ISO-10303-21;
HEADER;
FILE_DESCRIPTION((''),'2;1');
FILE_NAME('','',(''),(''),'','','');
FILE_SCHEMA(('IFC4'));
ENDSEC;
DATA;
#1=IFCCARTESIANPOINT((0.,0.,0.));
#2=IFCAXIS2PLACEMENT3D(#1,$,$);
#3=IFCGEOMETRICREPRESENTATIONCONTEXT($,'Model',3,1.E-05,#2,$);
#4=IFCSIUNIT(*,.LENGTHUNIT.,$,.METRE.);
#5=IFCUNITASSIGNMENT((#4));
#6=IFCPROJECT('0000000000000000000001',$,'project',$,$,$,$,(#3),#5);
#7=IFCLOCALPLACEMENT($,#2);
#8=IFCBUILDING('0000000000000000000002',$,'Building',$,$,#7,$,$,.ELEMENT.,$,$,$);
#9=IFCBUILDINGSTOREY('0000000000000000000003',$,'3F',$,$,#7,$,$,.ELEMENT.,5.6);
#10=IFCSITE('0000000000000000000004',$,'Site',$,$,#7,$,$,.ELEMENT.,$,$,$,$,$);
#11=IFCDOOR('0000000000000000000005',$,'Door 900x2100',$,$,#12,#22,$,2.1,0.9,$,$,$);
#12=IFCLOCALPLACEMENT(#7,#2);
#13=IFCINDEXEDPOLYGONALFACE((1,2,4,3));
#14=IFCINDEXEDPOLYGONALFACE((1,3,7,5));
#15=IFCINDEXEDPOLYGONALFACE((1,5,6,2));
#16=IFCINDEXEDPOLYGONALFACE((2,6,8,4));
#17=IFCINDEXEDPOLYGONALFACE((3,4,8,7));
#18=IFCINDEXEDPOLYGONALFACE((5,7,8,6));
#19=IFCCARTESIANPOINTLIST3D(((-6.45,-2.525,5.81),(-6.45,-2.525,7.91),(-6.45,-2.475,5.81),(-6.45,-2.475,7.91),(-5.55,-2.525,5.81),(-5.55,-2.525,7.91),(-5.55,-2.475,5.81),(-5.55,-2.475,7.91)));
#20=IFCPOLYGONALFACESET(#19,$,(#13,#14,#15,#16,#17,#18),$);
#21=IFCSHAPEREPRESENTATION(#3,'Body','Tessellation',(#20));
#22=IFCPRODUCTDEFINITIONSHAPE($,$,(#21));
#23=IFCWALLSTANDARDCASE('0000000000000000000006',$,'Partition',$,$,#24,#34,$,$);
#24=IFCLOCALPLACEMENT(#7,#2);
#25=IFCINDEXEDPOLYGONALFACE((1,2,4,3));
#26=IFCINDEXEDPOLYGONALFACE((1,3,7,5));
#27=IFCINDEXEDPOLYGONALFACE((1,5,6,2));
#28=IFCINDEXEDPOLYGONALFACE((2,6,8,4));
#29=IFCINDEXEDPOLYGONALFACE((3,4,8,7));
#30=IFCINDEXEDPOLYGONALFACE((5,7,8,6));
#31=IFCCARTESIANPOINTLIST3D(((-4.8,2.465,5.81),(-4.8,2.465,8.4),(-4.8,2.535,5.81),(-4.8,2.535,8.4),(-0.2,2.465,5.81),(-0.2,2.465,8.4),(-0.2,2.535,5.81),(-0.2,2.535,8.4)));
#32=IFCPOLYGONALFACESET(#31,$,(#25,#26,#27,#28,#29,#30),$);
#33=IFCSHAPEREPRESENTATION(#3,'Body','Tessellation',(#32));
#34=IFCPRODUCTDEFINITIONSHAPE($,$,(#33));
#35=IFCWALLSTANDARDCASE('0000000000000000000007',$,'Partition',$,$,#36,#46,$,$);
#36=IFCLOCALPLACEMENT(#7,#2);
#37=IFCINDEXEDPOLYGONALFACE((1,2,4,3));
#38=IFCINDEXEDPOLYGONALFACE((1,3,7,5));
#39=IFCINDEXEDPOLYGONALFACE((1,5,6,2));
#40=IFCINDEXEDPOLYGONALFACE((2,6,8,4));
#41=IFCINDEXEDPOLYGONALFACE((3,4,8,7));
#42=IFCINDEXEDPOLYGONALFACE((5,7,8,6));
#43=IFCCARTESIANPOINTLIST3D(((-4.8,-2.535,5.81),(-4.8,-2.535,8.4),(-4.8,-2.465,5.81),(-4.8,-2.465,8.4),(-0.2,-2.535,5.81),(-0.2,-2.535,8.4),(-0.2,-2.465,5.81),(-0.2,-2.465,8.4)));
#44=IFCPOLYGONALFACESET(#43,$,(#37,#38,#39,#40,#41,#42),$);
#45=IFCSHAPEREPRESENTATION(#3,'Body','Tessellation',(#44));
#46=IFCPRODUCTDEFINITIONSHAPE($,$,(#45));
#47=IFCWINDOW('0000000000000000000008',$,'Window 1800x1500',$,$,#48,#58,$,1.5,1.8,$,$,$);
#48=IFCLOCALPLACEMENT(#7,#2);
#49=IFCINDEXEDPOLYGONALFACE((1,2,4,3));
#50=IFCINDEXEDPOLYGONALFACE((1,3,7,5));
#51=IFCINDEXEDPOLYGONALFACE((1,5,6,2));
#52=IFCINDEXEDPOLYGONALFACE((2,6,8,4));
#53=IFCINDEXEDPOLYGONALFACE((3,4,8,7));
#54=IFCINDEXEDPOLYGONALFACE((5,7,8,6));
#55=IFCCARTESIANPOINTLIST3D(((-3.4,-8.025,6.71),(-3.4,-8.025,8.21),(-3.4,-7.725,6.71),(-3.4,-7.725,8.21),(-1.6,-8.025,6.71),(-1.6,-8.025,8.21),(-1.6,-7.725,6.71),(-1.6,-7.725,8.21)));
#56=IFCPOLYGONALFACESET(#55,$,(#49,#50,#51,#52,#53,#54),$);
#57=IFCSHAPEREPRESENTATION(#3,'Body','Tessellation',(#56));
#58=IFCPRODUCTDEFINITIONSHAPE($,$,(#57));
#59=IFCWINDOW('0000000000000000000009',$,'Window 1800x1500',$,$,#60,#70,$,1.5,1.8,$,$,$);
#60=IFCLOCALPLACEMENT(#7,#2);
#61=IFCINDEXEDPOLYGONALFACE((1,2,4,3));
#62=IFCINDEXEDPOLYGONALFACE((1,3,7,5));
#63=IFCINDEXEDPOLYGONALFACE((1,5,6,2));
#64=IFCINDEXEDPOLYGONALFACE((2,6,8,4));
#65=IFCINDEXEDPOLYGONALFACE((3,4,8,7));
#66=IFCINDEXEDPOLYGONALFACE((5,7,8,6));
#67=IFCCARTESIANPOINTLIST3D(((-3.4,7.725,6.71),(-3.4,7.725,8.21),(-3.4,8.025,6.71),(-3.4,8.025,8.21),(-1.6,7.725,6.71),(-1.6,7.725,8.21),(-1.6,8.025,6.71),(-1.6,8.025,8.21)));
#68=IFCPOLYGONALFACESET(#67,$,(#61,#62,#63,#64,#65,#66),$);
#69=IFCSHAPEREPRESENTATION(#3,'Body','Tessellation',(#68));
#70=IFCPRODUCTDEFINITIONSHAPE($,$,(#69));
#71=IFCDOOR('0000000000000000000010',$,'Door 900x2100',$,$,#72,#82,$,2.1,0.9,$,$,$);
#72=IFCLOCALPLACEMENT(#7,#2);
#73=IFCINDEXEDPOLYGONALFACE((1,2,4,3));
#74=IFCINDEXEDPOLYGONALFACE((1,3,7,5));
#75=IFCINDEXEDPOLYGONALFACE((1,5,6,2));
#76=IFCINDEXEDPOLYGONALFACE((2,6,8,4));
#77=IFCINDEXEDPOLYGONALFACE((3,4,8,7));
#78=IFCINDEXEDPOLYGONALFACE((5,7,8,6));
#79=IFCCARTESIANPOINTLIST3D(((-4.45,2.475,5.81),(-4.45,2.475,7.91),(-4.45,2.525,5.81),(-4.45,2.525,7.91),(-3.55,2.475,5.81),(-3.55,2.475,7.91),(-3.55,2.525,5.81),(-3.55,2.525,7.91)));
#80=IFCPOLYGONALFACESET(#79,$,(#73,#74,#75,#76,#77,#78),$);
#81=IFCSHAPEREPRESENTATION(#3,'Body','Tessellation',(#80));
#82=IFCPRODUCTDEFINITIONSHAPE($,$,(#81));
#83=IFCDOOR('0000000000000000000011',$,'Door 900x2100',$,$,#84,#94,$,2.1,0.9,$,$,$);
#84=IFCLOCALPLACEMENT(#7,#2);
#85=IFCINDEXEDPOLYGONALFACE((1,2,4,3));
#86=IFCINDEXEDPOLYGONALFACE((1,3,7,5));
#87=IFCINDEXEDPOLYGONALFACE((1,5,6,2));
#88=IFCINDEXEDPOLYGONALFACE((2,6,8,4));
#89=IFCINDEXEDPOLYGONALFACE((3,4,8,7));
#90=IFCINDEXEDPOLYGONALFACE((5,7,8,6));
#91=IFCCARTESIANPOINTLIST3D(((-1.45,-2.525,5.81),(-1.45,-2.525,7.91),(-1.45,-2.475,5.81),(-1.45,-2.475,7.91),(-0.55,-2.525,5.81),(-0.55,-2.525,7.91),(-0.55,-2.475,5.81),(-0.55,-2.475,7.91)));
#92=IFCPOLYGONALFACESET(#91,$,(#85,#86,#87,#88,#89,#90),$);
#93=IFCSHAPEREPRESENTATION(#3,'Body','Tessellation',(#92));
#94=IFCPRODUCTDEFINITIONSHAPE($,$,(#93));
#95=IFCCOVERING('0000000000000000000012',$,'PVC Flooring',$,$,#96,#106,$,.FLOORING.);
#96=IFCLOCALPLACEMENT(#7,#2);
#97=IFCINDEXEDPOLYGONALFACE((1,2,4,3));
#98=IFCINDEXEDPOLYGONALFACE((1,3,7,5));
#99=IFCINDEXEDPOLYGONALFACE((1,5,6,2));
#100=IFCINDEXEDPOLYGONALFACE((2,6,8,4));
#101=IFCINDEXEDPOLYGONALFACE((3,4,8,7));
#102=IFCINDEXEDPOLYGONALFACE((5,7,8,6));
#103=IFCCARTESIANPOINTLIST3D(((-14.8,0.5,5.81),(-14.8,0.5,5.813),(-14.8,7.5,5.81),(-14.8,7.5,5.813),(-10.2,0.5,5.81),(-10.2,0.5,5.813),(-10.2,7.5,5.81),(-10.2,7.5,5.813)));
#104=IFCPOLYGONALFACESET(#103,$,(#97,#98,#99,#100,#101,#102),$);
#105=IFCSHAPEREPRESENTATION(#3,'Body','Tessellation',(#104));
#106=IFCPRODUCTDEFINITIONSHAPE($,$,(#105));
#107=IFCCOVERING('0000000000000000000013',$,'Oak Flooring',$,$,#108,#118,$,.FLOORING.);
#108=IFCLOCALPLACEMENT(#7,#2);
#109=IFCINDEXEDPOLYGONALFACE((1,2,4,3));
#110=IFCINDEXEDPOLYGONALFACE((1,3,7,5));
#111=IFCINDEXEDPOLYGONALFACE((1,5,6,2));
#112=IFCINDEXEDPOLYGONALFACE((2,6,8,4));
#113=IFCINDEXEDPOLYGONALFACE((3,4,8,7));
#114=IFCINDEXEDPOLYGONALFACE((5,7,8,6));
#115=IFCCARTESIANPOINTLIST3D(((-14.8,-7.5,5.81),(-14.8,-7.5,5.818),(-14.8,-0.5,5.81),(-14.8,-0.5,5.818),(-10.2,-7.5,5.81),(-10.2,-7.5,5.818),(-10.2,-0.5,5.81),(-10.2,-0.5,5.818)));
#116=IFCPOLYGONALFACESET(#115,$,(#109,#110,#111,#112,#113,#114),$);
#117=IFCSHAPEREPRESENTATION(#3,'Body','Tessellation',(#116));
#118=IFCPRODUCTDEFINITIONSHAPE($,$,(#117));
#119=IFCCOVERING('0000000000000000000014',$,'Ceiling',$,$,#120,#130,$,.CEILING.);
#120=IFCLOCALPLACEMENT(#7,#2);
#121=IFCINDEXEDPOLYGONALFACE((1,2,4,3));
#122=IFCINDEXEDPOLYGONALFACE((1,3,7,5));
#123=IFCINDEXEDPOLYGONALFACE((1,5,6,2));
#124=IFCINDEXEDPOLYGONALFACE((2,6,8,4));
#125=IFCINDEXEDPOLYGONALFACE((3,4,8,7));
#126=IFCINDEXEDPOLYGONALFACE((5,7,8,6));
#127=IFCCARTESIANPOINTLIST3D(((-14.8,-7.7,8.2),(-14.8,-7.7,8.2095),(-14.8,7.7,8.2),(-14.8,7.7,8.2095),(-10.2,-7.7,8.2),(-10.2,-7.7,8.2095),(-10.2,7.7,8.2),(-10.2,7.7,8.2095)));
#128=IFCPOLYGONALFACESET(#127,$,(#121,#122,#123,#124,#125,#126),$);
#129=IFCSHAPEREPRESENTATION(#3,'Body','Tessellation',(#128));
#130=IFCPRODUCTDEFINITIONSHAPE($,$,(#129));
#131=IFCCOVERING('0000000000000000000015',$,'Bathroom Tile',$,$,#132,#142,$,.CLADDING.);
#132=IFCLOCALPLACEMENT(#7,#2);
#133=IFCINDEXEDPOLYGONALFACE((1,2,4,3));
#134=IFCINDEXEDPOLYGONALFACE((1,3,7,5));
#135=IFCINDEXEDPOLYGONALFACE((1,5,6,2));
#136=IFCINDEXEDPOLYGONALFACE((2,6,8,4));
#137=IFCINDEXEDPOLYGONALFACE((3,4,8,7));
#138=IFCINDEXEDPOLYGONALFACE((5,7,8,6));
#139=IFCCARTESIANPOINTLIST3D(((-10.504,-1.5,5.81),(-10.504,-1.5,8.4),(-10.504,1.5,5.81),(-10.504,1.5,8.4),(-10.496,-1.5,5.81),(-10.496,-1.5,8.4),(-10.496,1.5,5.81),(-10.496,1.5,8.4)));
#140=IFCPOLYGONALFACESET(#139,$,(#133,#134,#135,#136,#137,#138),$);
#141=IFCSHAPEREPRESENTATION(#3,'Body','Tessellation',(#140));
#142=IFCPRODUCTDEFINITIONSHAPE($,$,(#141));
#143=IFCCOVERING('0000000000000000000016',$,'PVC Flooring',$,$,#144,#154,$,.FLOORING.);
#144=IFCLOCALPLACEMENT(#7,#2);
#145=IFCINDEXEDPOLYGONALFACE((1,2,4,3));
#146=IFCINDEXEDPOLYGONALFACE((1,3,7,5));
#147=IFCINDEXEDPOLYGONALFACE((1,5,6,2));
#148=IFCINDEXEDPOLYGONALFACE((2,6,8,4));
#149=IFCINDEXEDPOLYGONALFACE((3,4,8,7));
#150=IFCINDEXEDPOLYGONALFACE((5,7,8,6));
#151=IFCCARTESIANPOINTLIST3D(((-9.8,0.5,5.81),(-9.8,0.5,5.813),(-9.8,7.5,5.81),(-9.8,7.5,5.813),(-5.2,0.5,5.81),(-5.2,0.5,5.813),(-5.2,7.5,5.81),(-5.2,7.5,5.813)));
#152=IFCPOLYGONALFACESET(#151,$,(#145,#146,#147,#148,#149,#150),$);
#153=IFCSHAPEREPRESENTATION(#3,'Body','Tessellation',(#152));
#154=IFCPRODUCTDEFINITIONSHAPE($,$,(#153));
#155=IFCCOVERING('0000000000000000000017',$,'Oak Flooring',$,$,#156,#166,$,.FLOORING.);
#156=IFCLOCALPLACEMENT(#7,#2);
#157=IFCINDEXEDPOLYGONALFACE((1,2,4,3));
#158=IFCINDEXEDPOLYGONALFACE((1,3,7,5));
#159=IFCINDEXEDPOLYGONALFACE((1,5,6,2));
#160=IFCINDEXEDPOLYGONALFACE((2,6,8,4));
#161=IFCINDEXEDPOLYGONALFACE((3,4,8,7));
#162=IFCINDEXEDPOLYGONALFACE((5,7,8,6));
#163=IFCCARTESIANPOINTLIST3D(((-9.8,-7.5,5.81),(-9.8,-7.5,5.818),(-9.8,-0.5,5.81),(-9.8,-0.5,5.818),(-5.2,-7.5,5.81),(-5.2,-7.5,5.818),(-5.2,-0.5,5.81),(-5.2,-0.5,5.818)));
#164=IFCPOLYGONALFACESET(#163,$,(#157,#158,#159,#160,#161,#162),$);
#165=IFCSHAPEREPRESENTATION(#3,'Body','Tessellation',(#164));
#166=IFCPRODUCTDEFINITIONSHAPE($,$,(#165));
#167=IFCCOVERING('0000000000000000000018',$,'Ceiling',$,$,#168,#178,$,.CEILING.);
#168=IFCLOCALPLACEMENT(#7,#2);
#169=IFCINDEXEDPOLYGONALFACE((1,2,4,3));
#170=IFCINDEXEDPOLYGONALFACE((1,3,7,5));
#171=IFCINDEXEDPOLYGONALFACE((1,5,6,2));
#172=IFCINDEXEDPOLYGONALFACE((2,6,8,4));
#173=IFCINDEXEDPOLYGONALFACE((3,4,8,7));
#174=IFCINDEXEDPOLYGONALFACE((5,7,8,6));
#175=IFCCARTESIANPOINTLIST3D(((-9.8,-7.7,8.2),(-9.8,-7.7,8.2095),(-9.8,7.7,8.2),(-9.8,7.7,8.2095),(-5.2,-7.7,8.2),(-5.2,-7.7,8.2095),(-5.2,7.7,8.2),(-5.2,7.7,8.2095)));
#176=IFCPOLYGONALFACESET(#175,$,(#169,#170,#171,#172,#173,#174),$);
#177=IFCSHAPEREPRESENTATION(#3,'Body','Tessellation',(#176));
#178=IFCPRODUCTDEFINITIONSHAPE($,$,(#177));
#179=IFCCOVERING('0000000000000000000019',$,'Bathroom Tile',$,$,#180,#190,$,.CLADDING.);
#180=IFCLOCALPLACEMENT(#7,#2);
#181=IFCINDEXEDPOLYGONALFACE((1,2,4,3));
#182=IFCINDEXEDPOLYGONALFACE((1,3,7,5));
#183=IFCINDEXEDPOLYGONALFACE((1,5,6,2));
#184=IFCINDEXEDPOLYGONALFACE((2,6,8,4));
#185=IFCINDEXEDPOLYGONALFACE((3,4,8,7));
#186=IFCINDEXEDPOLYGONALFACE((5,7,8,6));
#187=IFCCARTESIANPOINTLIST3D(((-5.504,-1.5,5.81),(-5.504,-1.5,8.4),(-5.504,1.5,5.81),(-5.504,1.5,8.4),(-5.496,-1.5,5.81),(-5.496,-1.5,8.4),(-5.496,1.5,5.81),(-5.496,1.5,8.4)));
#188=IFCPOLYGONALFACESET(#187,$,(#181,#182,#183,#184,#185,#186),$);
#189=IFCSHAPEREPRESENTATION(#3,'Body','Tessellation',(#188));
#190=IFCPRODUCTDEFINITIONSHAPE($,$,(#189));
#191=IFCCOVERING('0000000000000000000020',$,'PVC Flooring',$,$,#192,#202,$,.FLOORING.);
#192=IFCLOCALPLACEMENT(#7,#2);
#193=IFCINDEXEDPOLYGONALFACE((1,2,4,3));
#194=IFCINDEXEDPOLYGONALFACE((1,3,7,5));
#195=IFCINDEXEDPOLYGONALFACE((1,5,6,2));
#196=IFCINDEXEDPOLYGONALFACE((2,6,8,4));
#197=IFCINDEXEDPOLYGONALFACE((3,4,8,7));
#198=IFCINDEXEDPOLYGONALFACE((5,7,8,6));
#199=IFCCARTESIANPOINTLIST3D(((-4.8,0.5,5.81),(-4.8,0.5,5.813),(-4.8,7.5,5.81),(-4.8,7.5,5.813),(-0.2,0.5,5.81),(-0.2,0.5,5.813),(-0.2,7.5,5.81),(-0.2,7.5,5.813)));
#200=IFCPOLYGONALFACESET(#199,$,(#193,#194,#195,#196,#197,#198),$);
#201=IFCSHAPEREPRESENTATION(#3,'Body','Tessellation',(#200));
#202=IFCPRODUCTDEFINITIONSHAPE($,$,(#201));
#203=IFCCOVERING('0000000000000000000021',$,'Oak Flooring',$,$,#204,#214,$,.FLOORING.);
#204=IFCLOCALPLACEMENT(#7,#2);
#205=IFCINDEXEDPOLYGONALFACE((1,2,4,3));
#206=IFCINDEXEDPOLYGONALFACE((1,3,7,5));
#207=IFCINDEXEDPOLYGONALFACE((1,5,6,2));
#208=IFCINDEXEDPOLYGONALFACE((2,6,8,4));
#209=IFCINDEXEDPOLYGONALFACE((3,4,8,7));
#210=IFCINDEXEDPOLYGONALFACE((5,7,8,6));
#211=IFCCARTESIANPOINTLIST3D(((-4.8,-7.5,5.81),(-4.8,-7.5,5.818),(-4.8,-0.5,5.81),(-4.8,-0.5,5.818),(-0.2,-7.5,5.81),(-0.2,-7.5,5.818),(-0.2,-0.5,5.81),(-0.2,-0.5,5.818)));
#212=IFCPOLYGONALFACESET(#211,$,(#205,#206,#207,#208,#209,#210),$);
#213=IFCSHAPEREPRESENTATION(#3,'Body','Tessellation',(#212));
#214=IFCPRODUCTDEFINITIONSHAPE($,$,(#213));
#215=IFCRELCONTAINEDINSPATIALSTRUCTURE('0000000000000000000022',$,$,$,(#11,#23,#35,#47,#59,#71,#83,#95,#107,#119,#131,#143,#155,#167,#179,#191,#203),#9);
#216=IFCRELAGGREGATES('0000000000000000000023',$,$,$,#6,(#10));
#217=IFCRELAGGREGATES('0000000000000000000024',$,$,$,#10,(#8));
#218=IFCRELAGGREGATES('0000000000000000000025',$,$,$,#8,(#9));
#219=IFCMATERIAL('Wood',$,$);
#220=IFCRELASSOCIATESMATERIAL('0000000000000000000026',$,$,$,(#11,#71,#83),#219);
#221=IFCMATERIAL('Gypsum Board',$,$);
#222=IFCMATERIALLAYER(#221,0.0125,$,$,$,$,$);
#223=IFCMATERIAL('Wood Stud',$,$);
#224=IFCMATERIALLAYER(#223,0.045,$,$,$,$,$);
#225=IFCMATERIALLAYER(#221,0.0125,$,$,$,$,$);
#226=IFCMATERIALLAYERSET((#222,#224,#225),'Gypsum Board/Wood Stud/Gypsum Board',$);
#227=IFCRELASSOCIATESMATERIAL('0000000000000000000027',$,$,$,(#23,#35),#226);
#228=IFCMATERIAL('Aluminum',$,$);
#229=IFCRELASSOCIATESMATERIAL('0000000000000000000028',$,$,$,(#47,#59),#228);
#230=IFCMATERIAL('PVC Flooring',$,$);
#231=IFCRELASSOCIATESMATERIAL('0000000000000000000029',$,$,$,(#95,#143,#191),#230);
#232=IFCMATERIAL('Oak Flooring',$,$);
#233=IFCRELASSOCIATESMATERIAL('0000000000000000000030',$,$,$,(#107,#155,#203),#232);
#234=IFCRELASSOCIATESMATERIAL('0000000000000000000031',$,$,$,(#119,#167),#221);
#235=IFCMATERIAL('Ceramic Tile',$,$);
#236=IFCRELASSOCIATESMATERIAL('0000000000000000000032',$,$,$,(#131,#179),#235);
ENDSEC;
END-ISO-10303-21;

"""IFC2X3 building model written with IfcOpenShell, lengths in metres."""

from ifc_helpers import new_model, si_unit, frame, origin, origin_2d, place, context, project, spatial, rectangle, extrude, material, layer, layer_set, layer_usage, element, save


model = new_model("IFC2X3")

# Units and contexts
model_context = context("Model", 3, precision=1e-05, world=origin())
ifc_project = project(units=[si_unit("LENGTHUNIT", "METRE")], contexts=[model_context])

# Site, building, storey
placement = place(None, origin())
site = spatial("IfcSite", under=ifc_project, at=placement, Name="Site", CompositionType="ELEMENT")
building = spatial("IfcBuilding", under=site, at=placement, Name="Building", CompositionType="ELEMENT")
storey = spatial("IfcBuildingStorey", under=building, at=placement, Name="3F", CompositionType="ELEMENT", Elevation=5.6)

# Shared definitions
ifc_material_1 = material(Name="Gypsum Board")
ifc_layer_1 = layer(ifc_material_1, 0.0125)
ifc_material_2 = material(Name="Wood Stud")
ifc_layer_2 = layer(ifc_material_2, 0.045)
ifc_layer_3 = layer(ifc_material_1, 0.0125)
ifc_layer_set_1 = layer_set([ifc_layer_1, ifc_layer_2, ifc_layer_3], Name="Gypsum Board/Wood Stud/Gypsum Board")
ifc_layer_usage_1 = layer_usage(ifc_layer_set_1, "AXIS2", "POSITIVE", 0.0)

# Shared definitions
ifc_material_3 = material(Name="Aluminum")

# Shared definitions
ifc_material_4 = material(Name="Wood")

# Door
for number, where, name in (
    (1, (-6.0, -2.5, 5.81), "Door 900x2100"),
):
    element("IfcDoor", number, at=place(None, frame(where)), inside=storey, material=ifc_material_4, Name=name, OverallHeight=2.1, OverallWidth=0.9, context=model_context, shape_type="SweptSolid", body=[
        extrude(rectangle(XDim=0.9, YDim=0.05, at=origin_2d()), origin(), (0.0, 0.0, 1.0), 2.1),
    ])

# Walls
for number, where, name in (
    (2, (-2.5, 2.5, 5.81), "Partition"),
    (3, (-2.5, -2.5, 5.81), "Partition"),
):
    element("IfcWallStandardCase", number, at=place(None, frame(where)), inside=storey, material=ifc_layer_usage_1, Name=name, context=model_context, shape_type="SweptSolid", body=[
        extrude(rectangle(XDim=4.6, YDim=0.07, at=origin_2d()), origin(), (0.0, 0.0, 1.0), 2.59),
    ])

# Windows
for number, where, name in (
    (4, (-2.5, -7.875, 6.71), "Window 1800x1500"),
    (5, (-2.5, 7.875, 6.71), "Window 1800x1500"),
):
    element("IfcWindow", number, at=place(None, frame(where)), inside=storey, material=ifc_material_3, Name=name, OverallHeight=1.5, OverallWidth=1.8, context=model_context, shape_type="SweptSolid", body=[
        extrude(rectangle(XDim=1.8, YDim=0.3, at=origin_2d()), origin(), (0.0, 0.0, 1.0), 1.5),
    ])

# Doors
for number, where, name in (
    (6, (-4.0, 2.5, 5.81), "Door 900x2100"),
    (7, (-1.0, -2.5, 5.81), "Door 900x2100"),
):
    element("IfcDoor", number, at=place(None, frame(where)), inside=storey, material=ifc_material_4, Name=name, OverallHeight=2.1, OverallWidth=0.9, context=model_context, shape_type="SweptSolid", body=[
        extrude(rectangle(XDim=0.9, YDim=0.05, at=origin_2d()), origin(), (0.0, 0.0, 1.0), 2.1),
    ])

# Coverings
ifc_material_5 = material(Name="PVC Flooring")
covering_1_placement = place(None, frame((-12.5, 4.0, 5.81)))
element("IfcCovering", 8, at=covering_1_placement, inside=storey, material=ifc_material_5, Name="PVC Flooring", PredefinedType="FLOORING", context=model_context, shape_type="SweptSolid", body=[
    extrude(rectangle(XDim=4.6, YDim=7.0, at=origin_2d()), origin(), (0.0, 0.0, 1.0), 0.003),
])
ifc_material_6 = material(Name="Oak Flooring")
covering_2_placement = place(None, frame((-12.5, -4.0, 5.81)))
element("IfcCovering", 9, at=covering_2_placement, inside=storey, material=ifc_material_6, Name="Oak Flooring", PredefinedType="FLOORING", context=model_context, shape_type="SweptSolid", body=[
    extrude(rectangle(XDim=4.6, YDim=7.0, at=origin_2d()), origin(), (0.0, 0.0, 1.0), 0.008),
])
covering_3_placement = place(None, frame((-12.5, 0.0, 8.2)))
element("IfcCovering", 10, at=covering_3_placement, inside=storey, material=ifc_material_1, Name="Ceiling", PredefinedType="CEILING", context=model_context, shape_type="SweptSolid", body=[
    extrude(rectangle(XDim=4.6, YDim=15.4, at=origin_2d()), origin(), (0.0, 0.0, 1.0), 0.0095),
])
ifc_material_7 = material(Name="Ceramic Tile")
covering_4_placement = place(None, frame((-10.5, 0.0, 5.81)))
element("IfcCovering", 11, at=covering_4_placement, inside=storey, material=ifc_material_7, Name="Bathroom Tile", PredefinedType="CLADDING", context=model_context, shape_type="SweptSolid", body=[
    extrude(rectangle(XDim=0.008, YDim=3.0, at=origin_2d()), origin(), (0.0, 0.0, 1.0), 2.59),
])
covering_5_placement = place(None, frame((-7.5, 4.0, 5.81)))
element("IfcCovering", 12, at=covering_5_placement, inside=storey, material=ifc_material_5, Name="PVC Flooring", PredefinedType="FLOORING", context=model_context, shape_type="SweptSolid", body=[
    extrude(rectangle(XDim=4.6, YDim=7.0, at=origin_2d()), origin(), (0.0, 0.0, 1.0), 0.003),
])
covering_6_placement = place(None, frame((-7.5, -4.0, 5.81)))
element("IfcCovering", 13, at=covering_6_placement, inside=storey, material=ifc_material_6, Name="Oak Flooring", PredefinedType="FLOORING", context=model_context, shape_type="SweptSolid", body=[
    extrude(rectangle(XDim=4.6, YDim=7.0, at=origin_2d()), origin(), (0.0, 0.0, 1.0), 0.008),
])
covering_7_placement = place(None, frame((-7.5, 0.0, 8.2)))
element("IfcCovering", 14, at=covering_7_placement, inside=storey, material=ifc_material_1, Name="Ceiling", PredefinedType="CEILING", context=model_context, shape_type="SweptSolid", body=[
    extrude(rectangle(XDim=4.6, YDim=15.4, at=origin_2d()), origin(), (0.0, 0.0, 1.0), 0.0095),
])
covering_8_placement = place(None, frame((-5.5, 0.0, 5.81)))
element("IfcCovering", 15, at=covering_8_placement, inside=storey, material=ifc_material_7, Name="Bathroom Tile", PredefinedType="CLADDING", context=model_context, shape_type="SweptSolid", body=[
    extrude(rectangle(XDim=0.008, YDim=3.0, at=origin_2d()), origin(), (0.0, 0.0, 1.0), 2.59),
])
covering_9_placement = place(None, frame((-2.5, 4.0, 5.81)))
element("IfcCovering", 16, at=covering_9_placement, inside=storey, material=ifc_material_5, Name="PVC Flooring", PredefinedType="FLOORING", context=model_context, shape_type="SweptSolid", body=[
    extrude(rectangle(XDim=4.6, YDim=7.0, at=origin_2d()), origin(), (0.0, 0.0, 1.0), 0.003),
])
covering_10_placement = place(None, frame((-2.5, -4.0, 5.81)))
element("IfcCovering", 17, at=covering_10_placement, inside=storey, material=ifc_material_6, Name="Oak Flooring", PredefinedType="FLOORING", context=model_context, shape_type="SweptSolid", body=[
    extrude(rectangle(XDim=4.6, YDim=7.0, at=origin_2d()), origin(), (0.0, 0.0, 1.0), 0.008),
])

save(model, "model.ifc")
